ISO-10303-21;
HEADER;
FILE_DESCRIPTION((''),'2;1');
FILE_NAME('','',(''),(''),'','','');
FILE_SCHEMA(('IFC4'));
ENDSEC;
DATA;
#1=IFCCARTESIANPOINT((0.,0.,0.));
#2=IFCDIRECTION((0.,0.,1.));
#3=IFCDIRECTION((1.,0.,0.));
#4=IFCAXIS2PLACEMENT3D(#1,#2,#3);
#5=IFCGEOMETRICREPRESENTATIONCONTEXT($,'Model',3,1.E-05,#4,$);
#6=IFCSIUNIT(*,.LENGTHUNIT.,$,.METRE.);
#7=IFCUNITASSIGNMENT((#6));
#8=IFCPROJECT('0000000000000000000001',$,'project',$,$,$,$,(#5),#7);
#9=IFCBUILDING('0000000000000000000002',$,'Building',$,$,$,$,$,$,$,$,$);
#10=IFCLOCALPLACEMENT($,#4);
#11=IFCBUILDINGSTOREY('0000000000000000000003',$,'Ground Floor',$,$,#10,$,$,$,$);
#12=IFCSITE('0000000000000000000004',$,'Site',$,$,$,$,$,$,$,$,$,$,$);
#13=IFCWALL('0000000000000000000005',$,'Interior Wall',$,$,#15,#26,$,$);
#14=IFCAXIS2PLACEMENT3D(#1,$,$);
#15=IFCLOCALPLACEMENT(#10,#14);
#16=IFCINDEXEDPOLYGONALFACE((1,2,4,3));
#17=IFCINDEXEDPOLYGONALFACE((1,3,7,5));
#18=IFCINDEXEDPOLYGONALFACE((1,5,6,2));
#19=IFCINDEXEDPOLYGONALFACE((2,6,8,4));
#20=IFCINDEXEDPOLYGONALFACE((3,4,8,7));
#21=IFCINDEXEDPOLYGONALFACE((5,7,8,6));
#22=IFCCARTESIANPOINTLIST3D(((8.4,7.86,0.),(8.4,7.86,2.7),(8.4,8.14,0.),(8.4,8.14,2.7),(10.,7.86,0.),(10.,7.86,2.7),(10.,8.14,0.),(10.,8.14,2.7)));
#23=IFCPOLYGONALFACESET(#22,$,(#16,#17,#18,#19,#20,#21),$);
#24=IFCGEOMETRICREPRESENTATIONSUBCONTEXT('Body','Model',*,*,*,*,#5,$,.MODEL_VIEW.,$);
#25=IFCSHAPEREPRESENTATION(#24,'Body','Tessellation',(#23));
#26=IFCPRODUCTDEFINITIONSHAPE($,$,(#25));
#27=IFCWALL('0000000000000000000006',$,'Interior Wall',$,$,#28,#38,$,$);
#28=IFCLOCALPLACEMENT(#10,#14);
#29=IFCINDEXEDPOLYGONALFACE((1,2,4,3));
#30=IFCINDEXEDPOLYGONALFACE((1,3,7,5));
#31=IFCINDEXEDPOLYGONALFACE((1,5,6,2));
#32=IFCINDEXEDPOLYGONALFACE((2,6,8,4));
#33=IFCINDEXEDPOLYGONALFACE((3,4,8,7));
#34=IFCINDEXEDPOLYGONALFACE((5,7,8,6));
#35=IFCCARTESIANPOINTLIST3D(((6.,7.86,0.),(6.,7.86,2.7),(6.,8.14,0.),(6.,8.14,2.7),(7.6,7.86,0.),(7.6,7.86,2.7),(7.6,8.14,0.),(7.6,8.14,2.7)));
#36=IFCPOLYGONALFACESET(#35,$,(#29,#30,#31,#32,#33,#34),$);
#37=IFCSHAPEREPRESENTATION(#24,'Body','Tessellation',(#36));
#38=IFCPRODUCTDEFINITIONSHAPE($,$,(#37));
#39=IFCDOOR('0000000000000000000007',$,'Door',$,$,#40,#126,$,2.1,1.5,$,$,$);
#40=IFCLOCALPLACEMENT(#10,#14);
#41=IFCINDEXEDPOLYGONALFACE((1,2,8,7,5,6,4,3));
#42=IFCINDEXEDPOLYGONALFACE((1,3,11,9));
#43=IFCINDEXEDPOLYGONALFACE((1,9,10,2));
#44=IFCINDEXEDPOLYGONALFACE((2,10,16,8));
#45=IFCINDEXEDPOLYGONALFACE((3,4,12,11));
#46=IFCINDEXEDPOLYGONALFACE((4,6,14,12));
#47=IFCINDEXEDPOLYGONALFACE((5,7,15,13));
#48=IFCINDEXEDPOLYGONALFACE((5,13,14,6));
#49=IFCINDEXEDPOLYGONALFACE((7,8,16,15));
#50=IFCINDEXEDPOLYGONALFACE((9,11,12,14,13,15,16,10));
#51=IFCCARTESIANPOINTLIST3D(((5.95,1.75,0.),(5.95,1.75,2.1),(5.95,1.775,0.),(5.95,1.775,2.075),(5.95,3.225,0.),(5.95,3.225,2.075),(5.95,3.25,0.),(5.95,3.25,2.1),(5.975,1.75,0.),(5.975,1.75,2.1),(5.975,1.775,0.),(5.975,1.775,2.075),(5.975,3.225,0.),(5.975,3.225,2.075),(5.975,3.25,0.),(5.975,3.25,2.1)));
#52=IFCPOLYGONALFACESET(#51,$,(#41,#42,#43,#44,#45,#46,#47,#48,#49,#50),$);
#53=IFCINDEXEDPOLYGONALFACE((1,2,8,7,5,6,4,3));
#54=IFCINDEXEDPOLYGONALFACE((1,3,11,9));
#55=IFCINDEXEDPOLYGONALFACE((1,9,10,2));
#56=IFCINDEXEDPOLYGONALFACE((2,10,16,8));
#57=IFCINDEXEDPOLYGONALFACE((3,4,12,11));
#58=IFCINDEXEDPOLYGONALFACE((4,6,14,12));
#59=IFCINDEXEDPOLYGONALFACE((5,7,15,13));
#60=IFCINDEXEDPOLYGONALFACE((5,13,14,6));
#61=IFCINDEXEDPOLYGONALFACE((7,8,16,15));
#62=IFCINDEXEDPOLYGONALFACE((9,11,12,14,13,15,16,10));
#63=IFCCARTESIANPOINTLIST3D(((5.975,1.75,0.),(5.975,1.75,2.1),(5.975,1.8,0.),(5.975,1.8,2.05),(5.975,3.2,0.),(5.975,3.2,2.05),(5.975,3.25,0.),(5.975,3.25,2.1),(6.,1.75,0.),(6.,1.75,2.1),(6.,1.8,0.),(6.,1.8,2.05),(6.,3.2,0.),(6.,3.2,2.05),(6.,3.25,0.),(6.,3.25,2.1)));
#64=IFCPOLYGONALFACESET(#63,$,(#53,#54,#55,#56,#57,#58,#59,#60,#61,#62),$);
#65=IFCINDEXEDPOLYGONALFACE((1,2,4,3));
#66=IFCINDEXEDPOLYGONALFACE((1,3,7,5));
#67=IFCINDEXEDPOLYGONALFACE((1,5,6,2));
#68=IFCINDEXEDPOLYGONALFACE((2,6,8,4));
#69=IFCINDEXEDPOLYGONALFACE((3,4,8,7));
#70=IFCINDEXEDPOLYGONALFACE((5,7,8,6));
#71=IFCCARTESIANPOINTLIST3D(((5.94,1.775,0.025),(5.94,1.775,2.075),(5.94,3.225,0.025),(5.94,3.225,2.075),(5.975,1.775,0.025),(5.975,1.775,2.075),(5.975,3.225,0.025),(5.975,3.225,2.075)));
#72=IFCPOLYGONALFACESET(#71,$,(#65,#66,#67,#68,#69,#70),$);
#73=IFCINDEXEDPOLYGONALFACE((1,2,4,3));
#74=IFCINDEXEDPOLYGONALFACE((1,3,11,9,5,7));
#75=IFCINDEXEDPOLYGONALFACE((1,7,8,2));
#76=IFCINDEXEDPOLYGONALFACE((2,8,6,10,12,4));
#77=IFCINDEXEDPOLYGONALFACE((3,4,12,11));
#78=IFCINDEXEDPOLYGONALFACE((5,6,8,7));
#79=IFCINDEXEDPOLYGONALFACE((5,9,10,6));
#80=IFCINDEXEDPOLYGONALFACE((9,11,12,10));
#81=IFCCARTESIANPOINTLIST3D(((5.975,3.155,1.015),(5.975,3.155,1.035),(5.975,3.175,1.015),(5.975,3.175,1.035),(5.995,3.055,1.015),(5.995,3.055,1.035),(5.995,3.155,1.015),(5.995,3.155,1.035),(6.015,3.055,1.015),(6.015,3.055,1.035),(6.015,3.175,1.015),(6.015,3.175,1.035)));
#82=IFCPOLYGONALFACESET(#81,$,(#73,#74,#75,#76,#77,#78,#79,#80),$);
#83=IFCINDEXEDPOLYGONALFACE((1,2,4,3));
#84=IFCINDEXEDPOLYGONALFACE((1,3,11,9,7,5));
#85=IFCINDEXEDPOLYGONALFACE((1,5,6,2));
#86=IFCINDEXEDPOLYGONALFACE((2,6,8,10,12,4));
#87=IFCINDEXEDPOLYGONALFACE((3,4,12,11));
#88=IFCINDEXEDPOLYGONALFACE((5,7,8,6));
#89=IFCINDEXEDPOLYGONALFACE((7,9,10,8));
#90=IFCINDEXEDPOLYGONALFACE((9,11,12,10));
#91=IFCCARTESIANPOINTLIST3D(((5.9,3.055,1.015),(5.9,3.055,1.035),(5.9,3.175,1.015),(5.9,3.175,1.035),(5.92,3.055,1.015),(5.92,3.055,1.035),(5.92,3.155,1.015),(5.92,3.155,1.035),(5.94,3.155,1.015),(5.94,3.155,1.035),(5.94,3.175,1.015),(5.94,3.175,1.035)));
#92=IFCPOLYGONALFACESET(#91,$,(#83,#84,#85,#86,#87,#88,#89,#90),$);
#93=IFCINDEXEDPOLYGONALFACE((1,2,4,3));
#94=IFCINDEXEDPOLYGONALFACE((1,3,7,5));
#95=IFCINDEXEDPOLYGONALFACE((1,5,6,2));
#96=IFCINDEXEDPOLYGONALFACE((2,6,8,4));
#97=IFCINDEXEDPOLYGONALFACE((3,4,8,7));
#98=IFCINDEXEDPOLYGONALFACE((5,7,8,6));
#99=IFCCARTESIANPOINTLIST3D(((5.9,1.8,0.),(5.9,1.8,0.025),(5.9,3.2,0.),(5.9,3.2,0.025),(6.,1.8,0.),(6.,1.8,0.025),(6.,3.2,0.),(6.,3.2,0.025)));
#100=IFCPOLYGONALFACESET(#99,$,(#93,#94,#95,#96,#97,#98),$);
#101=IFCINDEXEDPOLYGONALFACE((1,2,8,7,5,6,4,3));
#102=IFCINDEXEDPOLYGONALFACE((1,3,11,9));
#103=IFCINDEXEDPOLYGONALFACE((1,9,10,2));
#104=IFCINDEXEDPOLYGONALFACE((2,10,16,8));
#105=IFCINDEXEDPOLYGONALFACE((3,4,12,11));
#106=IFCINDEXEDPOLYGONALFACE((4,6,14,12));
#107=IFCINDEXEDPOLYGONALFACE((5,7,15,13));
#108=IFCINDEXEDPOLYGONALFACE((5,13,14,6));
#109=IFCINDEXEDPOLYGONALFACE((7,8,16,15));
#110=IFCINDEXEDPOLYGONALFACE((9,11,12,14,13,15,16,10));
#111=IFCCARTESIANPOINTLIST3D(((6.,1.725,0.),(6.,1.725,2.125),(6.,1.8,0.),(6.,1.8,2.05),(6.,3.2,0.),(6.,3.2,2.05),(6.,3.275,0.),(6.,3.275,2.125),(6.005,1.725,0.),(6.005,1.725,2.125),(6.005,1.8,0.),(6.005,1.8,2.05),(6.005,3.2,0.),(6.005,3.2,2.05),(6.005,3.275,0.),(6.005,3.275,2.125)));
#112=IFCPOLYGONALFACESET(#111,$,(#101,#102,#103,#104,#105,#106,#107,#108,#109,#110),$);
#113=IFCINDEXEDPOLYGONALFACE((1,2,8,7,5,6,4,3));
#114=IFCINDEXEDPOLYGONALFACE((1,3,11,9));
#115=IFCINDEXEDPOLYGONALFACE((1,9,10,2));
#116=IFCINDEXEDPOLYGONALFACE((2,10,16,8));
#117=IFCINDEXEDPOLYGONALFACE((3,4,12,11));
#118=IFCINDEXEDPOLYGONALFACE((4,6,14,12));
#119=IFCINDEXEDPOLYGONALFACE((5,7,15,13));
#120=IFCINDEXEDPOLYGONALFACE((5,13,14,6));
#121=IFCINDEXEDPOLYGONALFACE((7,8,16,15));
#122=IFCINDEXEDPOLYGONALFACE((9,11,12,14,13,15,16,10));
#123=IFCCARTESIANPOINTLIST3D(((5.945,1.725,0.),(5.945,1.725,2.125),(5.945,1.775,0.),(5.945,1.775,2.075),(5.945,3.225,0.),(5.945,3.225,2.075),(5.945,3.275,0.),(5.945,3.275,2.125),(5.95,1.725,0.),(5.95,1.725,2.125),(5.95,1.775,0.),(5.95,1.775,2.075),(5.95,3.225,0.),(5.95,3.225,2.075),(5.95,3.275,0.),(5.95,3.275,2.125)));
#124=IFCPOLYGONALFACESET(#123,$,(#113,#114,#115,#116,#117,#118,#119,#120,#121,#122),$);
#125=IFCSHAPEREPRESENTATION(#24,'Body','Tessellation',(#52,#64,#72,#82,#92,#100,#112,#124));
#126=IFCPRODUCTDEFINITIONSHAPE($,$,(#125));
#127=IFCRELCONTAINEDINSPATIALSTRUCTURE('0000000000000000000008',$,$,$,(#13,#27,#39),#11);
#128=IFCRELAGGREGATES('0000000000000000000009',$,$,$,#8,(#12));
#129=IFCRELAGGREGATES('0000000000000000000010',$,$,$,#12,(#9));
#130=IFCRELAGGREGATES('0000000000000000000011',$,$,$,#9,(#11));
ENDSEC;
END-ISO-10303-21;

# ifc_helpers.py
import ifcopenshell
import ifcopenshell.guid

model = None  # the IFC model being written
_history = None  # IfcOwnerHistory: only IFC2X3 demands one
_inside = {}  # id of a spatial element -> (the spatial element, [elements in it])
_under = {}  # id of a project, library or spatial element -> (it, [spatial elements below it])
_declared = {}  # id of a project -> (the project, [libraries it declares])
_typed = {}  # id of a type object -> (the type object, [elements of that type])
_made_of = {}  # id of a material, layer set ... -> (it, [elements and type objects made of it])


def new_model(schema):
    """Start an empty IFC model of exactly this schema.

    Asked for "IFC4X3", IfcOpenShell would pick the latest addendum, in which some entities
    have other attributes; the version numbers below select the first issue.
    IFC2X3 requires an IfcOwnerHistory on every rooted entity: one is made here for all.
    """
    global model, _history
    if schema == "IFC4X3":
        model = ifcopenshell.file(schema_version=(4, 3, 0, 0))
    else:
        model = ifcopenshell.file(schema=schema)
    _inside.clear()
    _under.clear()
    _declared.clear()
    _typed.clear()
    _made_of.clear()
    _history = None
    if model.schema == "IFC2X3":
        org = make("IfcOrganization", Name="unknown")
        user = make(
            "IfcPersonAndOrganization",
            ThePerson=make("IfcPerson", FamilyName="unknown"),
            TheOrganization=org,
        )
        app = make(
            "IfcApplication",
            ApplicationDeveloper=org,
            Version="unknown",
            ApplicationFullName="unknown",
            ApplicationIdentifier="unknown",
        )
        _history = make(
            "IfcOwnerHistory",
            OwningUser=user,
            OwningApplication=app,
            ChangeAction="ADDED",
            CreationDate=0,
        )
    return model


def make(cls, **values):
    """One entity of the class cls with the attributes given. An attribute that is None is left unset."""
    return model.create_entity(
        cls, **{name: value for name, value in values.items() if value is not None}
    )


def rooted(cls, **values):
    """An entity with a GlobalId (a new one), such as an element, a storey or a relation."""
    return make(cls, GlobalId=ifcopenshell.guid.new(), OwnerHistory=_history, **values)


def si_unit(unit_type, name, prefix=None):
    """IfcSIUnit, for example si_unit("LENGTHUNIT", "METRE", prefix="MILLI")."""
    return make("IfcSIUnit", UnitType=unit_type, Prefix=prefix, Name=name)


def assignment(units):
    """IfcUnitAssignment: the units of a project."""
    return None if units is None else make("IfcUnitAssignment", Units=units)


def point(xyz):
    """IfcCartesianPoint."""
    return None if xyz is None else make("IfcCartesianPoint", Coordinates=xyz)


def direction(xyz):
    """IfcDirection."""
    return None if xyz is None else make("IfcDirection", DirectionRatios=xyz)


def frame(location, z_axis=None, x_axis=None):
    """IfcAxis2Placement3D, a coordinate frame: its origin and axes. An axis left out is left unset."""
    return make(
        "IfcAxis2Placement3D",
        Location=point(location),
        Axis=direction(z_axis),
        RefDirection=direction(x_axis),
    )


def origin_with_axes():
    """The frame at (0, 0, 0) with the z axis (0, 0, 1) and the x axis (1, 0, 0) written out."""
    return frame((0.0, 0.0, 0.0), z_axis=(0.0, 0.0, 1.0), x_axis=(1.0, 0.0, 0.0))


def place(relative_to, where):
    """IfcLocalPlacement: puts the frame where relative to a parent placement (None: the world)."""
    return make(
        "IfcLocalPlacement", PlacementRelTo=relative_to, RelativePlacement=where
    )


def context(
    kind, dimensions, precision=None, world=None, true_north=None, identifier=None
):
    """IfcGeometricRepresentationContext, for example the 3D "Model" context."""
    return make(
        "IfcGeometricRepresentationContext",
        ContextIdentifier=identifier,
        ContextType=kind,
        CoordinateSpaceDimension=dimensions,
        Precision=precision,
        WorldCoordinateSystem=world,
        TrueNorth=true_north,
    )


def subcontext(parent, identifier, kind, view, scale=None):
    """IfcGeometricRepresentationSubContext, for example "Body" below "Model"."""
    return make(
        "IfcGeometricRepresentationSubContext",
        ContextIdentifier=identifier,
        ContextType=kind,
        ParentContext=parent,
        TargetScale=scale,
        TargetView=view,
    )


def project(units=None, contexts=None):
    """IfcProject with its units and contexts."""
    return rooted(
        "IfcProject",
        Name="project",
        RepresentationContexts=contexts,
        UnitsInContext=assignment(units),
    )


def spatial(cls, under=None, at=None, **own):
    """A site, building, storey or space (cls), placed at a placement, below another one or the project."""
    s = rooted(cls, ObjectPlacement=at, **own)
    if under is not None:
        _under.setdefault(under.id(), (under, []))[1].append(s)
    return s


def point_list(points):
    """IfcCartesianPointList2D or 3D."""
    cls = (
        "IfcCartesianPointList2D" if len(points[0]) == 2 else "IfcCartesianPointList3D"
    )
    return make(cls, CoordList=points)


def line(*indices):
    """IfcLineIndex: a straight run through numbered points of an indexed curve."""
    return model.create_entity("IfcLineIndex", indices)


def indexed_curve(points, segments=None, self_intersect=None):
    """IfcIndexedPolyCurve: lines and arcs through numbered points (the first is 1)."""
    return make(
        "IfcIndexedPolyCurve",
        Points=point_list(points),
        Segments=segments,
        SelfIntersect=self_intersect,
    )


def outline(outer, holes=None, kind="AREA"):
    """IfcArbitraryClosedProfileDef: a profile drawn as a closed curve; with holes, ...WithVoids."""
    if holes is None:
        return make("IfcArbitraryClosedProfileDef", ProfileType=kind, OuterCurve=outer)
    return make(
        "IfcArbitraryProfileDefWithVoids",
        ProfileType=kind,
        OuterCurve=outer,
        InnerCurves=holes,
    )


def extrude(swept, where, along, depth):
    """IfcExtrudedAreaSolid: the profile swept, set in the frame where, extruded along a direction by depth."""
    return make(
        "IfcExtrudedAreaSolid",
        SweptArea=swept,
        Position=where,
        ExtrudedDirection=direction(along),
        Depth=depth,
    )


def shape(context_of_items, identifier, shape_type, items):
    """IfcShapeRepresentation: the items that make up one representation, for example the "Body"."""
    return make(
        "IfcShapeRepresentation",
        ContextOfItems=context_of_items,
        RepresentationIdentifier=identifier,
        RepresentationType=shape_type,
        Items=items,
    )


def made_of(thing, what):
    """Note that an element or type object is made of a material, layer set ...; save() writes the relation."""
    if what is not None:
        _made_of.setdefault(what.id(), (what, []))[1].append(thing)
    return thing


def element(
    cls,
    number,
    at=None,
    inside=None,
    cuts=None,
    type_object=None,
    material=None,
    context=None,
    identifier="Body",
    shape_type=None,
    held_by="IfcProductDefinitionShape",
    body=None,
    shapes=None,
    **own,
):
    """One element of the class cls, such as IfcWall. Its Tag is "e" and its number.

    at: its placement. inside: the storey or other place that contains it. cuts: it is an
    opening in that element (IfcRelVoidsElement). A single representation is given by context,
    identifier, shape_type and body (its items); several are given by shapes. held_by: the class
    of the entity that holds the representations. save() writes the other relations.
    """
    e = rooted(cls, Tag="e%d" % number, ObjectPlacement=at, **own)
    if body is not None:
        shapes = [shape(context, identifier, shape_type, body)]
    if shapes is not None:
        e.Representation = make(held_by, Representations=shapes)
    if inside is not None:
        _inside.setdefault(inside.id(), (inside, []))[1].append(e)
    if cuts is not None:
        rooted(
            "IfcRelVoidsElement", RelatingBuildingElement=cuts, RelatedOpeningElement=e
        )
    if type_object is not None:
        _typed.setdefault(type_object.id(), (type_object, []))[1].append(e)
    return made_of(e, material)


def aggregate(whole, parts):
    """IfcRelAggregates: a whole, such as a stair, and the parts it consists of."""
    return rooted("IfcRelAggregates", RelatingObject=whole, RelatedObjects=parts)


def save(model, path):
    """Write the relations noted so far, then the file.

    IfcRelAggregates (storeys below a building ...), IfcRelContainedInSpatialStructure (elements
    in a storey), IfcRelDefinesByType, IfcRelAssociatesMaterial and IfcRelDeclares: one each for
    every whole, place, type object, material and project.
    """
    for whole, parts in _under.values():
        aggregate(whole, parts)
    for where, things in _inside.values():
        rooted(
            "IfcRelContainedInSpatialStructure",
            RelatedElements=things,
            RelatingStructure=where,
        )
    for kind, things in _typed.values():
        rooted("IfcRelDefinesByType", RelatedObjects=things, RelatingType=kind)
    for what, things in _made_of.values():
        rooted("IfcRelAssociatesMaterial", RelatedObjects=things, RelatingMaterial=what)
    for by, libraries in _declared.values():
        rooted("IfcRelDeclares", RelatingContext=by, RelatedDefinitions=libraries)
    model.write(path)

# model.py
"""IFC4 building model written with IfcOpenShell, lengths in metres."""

from ifc_helpers import new_model, si_unit, frame, origin_with_axes, place, context, subcontext, project, spatial, line, indexed_curve, outline, extrude, element, save


model = new_model("IFC4")

# Units and contexts
model_context = context("Model", 3, precision=1e-05, world=origin_with_axes())
body_context = subcontext(model_context, "Body", "Model", "MODEL_VIEW")
ifc_project = project(units=[si_unit("LENGTHUNIT", "METRE")], contexts=[model_context])

# Site, building, storey
site = spatial("IfcSite", under=ifc_project, Name="Site")
building = spatial("IfcBuilding", under=site, Name="Building")
storey_placement = place(None, origin_with_axes())
storey = spatial("IfcBuildingStorey", under=building, at=storey_placement, Name="Ground Floor")

# Walls
for number, where, z_axis, x_axis, name in (
    (1, (10.0, 8.0, 0.0), (0.0, 0.0, 1.0), (-1.0, 0.0, 0.0), "Interior Wall"),
    (2, (7.6, 8.0, 0.0), (0.0, 0.0, 1.0), (-1.0, 0.0, 0.0), "Interior Wall"),
):
    element("IfcWall", number, at=place(storey_placement, frame(where, z_axis=z_axis, x_axis=x_axis)), inside=storey, Name=name, context=body_context, shape_type="SweptSolid", body=[
        extrude(outline(indexed_curve([(0.0, 0.0), (0.0, 0.28), (1.6, 0.28), (1.6, 0.0), (0.0, 0.0)], self_intersect=False)), frame((0.0, -0.14, 0.0), z_axis=(0.0, 0.0, 1.0), x_axis=(1.0, 0.0, 0.0)), (0.0, 0.0, 1.0), 2.7),
    ])

# Door
door_1_placement = place(storey_placement, frame((6.0, 1.75, 0.0), z_axis=(0.0, 0.0, 1.0), x_axis=(0.0, 1.0, 0.0)))
element("IfcDoor", 3, at=door_1_placement, inside=storey, Name="Door", OverallHeight=2.1, OverallWidth=1.5, context=body_context, shape_type="SweptSolid", body=[
    extrude(outline(indexed_curve([(0.0, 0.0), (0.0, 2.1), (1.5, 2.1), (1.5, 0.0), (1.475, 0.0), (1.475, 2.075), (0.025, 2.075), (0.025, 0.0)], segments=[line(1, 2, 3, 4, 5, 6, 7, 8, 1)])), frame((0.0, 0.025, 0.0), z_axis=(0.0, -1.0, 0.0), x_axis=(1.0, 0.0, 0.0)), (0.0, 0.0, -1.0), 0.025),
    extrude(outline(indexed_curve([(0.0, 0.0), (0.0, 2.1), (1.5, 2.1), (1.5, 0.0), (1.45, 0.0), (1.45, 2.05), (0.05, 2.05), (0.05, 0.0)], segments=[line(1, 2, 3, 4, 5, 6, 7, 8, 1)])), frame((0.0, 0.0, 0.0), z_axis=(0.0, -1.0, 0.0), x_axis=(1.0, 0.0, 0.0)), (0.0, 0.0, -1.0), 0.025),
    extrude(outline(indexed_curve([(0.0, 0.0), (1.45, 0.0), (1.45, 0.035), (0.0, 0.035)], segments=[line(1, 2, 3, 4, 1)])), frame((0.025, 0.025, 0.025), z_axis=(0.0, 0.0, 1.0), x_axis=(1.0, 0.0, 0.0)), (0.0, 0.0, 1.0), 2.05),
    extrude(outline(indexed_curve([(0.0, 0.0), (0.0, -0.04), (-0.12, -0.04), (-0.12, -0.02), (-0.02, -0.02), (-0.02, 0.0)], segments=[line(1, 2, 3, 4, 5, 6, 1)])), frame((1.425, 0.025, 1.015), z_axis=(0.0, 0.0, 1.0), x_axis=(1.0, 0.0, 0.0)), (0.0, 0.0, 1.0), 0.02),
    extrude(outline(indexed_curve([(0.0, 0.0), (0.0, 0.04), (-0.12, 0.04), (-0.12, 0.02), (-0.02, 0.02), (-0.02, 0.0)], segments=[line(1, 2, 3, 4, 5, 6, 1)])), frame((1.425, 0.06, 1.015), z_axis=(0.0, 0.0, 1.0), x_axis=(1.0, 0.0, 0.0)), (0.0, 0.0, 1.0), 0.02),
    extrude(outline(indexed_curve([(0.0, 0.0), (1.4, 0.0), (1.4, 0.1), (0.0, 0.1)], segments=[line(1, 2, 3, 4, 1)])), frame((0.05, 0.0, 0.0), z_axis=(0.0, 0.0, 1.0), x_axis=(1.0, 0.0, 0.0)), (0.0, 0.0, 1.0), 0.025),
    extrude(outline(indexed_curve([(0.0, 0.0), (0.0, 2.125), (1.55, 2.125), (1.55, 0.0), (1.475, 0.0), (1.475, 2.05), (0.075, 2.05), (0.075, 0.0)], segments=[line(1, 2, 3, 4, 5, 6, 7, 8, 1)])), frame((-0.025, -0.005, 0.0), z_axis=(0.0, -1.0, 0.0), x_axis=(1.0, 0.0, 0.0)), (0.0, 0.0, -1.0), 0.005),
    extrude(outline(indexed_curve([(0.0, 0.0), (0.0, 2.125), (1.55, 2.125), (1.55, 0.0), (1.5, 0.0), (1.5, 2.075), (0.05, 2.075), (0.05, 0.0)], segments=[line(1, 2, 3, 4, 5, 6, 7, 8, 1)])), frame((-0.025, 0.05, 0.0), z_axis=(0.0, -1.0, 0.0), x_axis=(1.0, 0.0, 0.0)), (0.0, 0.0, -1.0), 0.005),
])

save(model, "model.ifc")
